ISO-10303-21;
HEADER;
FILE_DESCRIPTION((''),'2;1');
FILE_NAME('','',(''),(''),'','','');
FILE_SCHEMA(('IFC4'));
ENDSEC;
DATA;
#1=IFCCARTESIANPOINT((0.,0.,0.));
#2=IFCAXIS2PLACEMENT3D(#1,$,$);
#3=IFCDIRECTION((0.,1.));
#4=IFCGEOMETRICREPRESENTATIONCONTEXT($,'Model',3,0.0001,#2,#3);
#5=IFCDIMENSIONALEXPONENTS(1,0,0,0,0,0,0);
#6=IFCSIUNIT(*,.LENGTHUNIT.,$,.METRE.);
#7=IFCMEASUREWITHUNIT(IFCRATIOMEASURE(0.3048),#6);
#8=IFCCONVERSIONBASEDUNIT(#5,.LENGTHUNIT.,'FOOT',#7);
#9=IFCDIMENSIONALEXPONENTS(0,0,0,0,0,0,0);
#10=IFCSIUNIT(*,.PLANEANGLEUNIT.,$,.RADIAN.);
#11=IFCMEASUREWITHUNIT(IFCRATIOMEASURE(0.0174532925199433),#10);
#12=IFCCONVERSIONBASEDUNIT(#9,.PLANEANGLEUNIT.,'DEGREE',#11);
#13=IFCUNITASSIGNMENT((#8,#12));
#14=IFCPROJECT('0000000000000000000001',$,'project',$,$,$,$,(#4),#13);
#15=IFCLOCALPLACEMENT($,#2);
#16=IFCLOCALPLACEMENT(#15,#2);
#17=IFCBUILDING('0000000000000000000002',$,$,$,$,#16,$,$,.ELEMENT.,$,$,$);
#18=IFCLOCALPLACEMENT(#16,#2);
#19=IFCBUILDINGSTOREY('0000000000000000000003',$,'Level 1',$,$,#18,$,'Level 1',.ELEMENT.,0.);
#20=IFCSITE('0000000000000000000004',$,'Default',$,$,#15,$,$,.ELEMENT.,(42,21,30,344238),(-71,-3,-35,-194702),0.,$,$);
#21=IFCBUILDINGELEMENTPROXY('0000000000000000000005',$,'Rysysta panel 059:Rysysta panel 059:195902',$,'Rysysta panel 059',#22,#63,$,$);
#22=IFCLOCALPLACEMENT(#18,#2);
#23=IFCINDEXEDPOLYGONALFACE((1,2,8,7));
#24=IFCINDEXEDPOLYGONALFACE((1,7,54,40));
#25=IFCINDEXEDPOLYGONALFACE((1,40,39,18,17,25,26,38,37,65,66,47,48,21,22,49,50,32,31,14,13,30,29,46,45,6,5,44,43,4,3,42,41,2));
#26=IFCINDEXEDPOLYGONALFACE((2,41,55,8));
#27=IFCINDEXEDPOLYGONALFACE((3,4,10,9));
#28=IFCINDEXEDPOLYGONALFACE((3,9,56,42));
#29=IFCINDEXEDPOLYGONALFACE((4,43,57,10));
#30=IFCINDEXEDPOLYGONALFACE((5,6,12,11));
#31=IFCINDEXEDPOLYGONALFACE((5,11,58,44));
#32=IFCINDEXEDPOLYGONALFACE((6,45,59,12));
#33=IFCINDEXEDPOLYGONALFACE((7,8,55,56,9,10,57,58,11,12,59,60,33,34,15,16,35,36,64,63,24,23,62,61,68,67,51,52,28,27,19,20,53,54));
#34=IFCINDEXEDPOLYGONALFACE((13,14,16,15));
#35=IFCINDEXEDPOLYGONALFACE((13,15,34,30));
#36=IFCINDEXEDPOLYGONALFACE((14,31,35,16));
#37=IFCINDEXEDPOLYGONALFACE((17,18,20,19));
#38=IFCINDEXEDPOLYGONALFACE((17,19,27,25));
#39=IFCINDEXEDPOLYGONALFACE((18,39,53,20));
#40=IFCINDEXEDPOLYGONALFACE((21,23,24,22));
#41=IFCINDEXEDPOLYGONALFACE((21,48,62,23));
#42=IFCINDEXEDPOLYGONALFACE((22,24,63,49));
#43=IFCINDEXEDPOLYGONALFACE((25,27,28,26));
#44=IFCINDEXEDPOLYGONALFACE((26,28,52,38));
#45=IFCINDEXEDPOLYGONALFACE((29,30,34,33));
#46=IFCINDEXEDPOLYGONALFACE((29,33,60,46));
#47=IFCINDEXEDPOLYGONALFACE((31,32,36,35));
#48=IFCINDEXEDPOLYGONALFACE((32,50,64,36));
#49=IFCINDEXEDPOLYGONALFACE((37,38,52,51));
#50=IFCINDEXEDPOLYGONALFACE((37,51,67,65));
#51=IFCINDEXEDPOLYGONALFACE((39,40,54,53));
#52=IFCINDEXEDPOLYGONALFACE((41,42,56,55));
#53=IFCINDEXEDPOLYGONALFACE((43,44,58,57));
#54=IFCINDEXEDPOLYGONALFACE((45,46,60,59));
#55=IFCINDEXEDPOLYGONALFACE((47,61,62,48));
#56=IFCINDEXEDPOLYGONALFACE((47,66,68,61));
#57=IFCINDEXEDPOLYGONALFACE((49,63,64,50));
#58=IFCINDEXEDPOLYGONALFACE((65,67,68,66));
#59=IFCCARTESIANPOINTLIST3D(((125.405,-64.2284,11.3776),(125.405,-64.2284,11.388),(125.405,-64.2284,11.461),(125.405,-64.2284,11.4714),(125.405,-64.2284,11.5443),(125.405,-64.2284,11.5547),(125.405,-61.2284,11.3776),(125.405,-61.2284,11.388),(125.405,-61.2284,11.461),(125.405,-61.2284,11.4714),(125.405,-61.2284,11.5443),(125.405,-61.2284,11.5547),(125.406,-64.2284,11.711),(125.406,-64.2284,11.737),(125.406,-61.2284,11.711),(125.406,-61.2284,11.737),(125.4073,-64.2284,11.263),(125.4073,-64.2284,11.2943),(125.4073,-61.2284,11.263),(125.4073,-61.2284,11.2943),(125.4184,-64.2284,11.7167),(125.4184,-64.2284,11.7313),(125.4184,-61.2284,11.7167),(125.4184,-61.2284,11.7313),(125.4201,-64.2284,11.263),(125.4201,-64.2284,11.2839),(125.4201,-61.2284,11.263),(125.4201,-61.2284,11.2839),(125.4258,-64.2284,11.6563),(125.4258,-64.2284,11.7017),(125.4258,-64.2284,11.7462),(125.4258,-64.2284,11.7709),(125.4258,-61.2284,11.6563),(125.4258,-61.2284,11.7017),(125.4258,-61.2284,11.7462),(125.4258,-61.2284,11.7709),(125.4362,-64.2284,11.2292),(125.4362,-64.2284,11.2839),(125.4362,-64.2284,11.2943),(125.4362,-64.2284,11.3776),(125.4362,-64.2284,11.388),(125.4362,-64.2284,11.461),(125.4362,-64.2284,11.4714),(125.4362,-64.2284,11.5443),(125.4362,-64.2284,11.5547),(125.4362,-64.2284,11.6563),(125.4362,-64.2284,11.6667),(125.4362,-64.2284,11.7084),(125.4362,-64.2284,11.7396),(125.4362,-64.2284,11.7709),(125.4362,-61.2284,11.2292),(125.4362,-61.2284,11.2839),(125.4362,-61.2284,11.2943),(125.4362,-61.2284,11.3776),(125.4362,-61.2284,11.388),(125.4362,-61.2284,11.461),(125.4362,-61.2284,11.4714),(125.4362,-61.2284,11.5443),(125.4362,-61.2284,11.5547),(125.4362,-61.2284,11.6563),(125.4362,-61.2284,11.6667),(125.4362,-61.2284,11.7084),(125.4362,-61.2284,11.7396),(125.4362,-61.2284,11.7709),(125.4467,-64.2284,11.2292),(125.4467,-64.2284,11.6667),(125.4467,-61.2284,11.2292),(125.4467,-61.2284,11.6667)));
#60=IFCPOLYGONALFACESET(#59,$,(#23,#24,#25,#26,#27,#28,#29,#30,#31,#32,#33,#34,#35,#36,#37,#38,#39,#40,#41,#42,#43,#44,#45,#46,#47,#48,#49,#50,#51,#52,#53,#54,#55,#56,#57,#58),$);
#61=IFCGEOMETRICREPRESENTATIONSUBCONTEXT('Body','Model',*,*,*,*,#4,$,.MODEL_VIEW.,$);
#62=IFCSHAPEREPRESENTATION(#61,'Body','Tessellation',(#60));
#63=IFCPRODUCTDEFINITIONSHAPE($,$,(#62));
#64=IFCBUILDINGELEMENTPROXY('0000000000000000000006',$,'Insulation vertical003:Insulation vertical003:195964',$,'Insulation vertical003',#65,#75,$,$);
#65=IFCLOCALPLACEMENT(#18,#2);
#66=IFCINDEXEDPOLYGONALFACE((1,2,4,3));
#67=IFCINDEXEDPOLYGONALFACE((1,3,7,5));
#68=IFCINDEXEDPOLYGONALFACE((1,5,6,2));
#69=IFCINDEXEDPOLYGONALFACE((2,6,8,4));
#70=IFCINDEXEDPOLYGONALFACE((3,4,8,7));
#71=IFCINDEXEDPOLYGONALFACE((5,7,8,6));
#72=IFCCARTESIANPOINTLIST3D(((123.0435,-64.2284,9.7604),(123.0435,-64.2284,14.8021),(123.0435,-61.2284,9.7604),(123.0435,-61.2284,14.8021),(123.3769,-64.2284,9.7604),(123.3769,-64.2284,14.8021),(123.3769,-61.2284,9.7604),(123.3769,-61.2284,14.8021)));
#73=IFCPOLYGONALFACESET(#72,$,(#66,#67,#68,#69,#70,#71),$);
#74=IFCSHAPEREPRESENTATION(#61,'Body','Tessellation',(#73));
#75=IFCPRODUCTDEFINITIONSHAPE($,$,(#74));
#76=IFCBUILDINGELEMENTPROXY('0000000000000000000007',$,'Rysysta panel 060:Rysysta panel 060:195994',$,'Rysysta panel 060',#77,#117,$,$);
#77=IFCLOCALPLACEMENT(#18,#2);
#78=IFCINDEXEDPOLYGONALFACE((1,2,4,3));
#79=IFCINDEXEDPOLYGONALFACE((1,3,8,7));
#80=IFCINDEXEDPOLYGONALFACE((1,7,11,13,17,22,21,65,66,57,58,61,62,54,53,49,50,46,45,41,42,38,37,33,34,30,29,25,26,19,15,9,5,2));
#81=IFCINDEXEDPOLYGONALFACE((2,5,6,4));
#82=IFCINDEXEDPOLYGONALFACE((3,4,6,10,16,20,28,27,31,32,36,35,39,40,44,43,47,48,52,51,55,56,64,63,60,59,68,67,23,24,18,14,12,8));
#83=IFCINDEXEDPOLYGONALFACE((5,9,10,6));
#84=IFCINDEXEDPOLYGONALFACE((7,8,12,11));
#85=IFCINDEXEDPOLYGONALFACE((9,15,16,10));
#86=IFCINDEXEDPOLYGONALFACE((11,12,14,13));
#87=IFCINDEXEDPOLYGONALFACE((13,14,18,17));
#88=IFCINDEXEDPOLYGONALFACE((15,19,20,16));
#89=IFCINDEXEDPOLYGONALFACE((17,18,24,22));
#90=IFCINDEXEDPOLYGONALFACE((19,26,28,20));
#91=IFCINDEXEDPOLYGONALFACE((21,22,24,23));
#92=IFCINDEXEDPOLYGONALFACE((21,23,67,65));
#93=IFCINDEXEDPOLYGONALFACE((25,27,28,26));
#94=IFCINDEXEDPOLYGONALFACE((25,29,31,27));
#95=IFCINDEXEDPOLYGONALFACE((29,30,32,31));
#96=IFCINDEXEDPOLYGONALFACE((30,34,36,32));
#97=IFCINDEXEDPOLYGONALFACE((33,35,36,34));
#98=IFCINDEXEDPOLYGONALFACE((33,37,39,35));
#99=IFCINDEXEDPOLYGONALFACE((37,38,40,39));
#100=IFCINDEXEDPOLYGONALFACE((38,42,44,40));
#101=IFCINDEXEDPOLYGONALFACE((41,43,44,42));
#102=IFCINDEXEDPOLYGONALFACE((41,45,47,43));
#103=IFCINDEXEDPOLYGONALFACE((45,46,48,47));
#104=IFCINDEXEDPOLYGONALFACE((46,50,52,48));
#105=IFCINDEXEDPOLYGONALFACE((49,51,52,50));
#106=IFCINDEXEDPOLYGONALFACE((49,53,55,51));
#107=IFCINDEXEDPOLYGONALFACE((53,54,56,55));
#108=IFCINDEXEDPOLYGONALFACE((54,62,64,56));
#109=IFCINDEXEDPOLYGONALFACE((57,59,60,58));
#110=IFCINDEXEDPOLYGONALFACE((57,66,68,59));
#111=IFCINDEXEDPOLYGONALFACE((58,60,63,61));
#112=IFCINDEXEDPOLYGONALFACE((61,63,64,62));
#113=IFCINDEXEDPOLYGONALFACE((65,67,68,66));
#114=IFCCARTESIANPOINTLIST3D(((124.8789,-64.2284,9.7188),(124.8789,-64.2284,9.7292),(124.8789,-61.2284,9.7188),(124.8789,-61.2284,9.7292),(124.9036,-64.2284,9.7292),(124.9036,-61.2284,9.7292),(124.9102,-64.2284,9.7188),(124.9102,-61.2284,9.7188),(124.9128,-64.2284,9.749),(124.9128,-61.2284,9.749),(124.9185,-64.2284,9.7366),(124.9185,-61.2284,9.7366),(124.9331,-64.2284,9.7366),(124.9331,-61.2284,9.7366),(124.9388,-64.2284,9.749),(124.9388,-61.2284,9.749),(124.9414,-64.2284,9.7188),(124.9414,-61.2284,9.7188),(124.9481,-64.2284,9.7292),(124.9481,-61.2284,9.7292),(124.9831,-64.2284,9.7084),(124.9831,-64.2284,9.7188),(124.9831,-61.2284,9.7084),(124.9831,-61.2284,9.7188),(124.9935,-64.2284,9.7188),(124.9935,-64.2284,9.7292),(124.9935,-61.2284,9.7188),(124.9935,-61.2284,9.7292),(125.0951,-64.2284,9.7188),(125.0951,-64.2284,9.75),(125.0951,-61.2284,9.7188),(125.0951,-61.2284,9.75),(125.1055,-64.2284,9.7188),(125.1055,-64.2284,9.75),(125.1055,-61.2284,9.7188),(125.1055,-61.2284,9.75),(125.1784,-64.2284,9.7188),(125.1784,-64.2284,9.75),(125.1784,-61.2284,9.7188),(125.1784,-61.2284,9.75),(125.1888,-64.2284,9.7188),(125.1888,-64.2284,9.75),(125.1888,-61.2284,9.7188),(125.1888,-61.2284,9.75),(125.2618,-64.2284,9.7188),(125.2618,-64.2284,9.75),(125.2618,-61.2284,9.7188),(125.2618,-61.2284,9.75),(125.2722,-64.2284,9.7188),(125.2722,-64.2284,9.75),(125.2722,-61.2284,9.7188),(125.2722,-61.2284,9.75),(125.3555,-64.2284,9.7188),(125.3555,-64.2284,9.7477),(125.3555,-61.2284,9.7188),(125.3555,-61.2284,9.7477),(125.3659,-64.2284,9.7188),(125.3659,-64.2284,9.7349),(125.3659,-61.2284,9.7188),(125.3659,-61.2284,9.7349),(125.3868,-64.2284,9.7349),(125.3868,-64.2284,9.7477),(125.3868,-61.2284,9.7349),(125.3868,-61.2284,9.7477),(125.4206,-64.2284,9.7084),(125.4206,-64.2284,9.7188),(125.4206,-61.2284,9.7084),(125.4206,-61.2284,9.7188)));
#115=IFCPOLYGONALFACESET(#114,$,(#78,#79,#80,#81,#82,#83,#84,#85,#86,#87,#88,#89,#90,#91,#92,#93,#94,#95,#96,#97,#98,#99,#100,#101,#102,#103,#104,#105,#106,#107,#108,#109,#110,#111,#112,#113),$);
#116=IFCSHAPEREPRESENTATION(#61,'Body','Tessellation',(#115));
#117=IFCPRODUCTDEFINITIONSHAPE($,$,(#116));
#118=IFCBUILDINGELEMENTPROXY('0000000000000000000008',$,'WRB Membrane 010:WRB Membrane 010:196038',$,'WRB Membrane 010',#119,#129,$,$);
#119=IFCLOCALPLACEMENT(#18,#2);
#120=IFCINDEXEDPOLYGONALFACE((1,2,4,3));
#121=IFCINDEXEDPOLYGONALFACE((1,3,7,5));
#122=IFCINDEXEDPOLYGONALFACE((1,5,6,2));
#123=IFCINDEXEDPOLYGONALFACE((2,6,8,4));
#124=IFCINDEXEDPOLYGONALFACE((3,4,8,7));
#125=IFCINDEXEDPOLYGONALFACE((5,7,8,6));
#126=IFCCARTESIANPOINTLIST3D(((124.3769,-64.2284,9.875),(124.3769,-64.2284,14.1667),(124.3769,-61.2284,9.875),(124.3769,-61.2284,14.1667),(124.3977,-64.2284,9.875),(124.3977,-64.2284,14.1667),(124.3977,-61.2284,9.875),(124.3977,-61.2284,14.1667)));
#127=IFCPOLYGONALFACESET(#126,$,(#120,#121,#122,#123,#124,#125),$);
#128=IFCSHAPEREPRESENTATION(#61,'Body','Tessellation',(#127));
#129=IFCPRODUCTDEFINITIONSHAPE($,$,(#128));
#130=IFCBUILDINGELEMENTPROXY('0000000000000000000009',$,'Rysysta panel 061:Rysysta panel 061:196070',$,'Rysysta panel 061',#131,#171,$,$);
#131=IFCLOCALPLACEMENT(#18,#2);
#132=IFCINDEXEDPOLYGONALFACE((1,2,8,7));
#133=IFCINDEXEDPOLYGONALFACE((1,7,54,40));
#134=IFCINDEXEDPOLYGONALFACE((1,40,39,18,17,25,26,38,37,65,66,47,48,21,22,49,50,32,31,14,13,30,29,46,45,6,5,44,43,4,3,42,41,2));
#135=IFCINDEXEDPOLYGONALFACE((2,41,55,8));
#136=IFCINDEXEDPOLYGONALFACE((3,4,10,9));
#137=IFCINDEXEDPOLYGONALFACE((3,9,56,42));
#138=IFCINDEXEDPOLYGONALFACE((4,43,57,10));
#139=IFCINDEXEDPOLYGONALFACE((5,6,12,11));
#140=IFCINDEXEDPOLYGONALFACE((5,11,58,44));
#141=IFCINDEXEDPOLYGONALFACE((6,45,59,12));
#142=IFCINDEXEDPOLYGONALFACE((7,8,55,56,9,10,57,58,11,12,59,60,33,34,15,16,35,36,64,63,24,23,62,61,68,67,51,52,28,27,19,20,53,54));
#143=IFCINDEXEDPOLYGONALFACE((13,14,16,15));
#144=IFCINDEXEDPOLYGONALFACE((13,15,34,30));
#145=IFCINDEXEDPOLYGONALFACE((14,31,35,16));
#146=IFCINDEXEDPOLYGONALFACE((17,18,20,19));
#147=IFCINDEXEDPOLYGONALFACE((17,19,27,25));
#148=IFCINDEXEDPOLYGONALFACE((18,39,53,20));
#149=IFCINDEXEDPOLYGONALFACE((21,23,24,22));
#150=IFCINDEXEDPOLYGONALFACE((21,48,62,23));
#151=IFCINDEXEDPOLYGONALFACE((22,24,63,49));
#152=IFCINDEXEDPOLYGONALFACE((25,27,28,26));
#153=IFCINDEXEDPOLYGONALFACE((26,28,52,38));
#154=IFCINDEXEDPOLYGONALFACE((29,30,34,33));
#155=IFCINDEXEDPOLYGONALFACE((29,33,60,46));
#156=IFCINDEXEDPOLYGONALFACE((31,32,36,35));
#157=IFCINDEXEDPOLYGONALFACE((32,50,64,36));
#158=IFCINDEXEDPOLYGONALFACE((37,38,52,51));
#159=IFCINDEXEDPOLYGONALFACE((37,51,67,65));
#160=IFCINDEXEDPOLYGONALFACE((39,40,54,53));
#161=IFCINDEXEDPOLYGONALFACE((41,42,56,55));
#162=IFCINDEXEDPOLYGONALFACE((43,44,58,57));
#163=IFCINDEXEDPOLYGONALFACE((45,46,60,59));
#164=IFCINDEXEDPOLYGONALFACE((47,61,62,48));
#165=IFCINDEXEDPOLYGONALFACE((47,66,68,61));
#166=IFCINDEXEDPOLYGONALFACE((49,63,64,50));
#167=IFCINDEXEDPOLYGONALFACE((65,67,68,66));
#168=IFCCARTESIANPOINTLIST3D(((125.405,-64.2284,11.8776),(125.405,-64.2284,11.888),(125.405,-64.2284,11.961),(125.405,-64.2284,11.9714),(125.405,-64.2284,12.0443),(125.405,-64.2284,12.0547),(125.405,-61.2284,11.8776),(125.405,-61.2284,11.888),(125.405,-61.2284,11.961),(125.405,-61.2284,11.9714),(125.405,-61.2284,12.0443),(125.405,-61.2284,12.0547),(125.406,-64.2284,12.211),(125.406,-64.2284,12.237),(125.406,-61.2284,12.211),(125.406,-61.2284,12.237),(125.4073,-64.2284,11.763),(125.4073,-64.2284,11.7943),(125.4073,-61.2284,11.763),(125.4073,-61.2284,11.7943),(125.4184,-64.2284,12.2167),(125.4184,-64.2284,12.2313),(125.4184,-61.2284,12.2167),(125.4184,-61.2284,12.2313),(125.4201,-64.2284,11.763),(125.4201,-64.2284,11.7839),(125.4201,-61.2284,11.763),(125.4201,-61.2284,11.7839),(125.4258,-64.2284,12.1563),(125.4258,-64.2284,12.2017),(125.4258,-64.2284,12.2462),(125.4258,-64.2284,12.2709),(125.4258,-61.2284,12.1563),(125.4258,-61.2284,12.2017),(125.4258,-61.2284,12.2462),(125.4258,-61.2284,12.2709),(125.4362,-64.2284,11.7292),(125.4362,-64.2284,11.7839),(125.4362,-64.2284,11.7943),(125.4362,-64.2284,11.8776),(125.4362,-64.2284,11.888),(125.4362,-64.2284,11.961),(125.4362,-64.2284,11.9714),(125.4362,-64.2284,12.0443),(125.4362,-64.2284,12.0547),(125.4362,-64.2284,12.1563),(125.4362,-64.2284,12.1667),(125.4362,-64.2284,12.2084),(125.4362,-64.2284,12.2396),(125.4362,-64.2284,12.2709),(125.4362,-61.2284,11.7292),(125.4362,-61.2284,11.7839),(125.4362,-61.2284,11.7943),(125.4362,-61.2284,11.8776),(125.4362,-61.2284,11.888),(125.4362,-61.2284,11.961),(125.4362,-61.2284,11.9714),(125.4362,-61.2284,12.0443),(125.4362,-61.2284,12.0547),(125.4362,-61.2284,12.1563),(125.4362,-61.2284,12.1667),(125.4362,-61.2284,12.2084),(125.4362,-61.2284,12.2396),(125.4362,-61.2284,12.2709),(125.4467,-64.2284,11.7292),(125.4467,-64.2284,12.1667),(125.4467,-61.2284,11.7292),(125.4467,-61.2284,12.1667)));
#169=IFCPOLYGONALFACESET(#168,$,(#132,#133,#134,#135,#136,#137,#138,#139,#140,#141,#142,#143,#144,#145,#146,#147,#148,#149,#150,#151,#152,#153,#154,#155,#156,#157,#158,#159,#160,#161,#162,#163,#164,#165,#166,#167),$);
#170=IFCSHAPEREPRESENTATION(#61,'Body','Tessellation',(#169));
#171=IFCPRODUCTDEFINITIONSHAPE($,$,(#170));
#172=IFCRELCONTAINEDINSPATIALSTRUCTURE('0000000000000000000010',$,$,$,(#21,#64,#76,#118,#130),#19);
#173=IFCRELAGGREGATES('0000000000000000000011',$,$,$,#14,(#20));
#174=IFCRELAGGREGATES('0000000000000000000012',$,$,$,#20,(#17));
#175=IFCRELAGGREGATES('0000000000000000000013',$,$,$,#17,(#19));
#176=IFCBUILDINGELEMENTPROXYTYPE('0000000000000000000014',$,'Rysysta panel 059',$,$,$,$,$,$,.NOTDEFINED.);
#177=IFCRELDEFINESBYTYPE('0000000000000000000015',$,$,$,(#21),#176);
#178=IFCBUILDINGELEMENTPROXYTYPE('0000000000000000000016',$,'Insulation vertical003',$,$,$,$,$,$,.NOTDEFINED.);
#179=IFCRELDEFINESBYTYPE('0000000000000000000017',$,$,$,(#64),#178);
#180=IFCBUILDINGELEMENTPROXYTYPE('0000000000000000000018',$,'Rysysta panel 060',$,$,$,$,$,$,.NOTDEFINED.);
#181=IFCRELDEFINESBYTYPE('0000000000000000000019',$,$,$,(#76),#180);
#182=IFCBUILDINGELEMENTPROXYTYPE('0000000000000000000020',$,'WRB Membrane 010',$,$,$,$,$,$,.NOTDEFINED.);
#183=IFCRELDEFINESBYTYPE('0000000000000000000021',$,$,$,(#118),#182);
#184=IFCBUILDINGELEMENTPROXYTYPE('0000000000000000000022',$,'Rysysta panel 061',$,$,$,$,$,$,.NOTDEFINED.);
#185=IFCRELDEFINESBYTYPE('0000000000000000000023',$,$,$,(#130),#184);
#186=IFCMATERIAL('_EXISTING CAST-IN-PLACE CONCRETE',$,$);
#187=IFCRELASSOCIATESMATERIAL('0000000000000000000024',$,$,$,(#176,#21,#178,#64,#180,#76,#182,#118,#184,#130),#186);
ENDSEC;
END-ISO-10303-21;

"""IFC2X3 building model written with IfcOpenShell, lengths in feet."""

from ifc_helpers import new_model, entity, si_unit, converted_unit, direction, frame, frame_2d, origin, origin_2d_with_axis, place, context, subcontext, project, spatial, polyline, rectangle, outline, extrude, source, transform, mapped, material, type_object, type_shapes, element, save


model = new_model("IFC2X3")

# Units and contexts
model_context = context("Model", 3, precision=0.0001, world=origin(), true_north=direction((0.0, 1.0)))
body_context = subcontext(model_context, "Body", "Model", "MODEL_VIEW")
ifc_project = project(units=[converted_unit("LENGTHUNIT", "FOOT", entity("IfcRatioMeasure", 0.3048), si_unit("LENGTHUNIT", "METRE"), dimensions=[1, 0, 0, 0, 0, 0, 0]), converted_unit("PLANEANGLEUNIT", "DEGREE", entity("IfcRatioMeasure", 0.0174532925199433), si_unit("PLANEANGLEUNIT", "RADIAN"), dimensions=[0, 0, 0, 0, 0, 0, 0])], contexts=[model_context])

# Site, building, storey
site_placement = place(None, origin())
site = spatial("IfcSite", under=ifc_project, at=site_placement, Name="Default", CompositionType="ELEMENT", RefLatitude=(42, 21, 30, 344238), RefLongitude=(-71, -3, -35, -194702), RefElevation=0.0)
building_placement = place(site_placement, origin())
building = spatial("IfcBuilding", under=site, at=building_placement, CompositionType="ELEMENT")
storey_placement = place(building_placement, origin())
storey = spatial("IfcBuildingStorey", under=building, at=storey_placement, Name="Level 1", LongName="Level 1", CompositionType="ELEMENT", Elevation=0.0)

# Building element proxies
ifc_material_1 = material(Name="_EXISTING CAST-IN-PLACE CONCRETE")
building_element_proxy_type_1 = type_object("IfcBuildingElementProxyType", Name="Rysysta panel 059", PredefinedType="NOTDEFINED", material=ifc_material_1)
shared_shape_1 = source(origin(), body_context, "Body", "SweptSolid", [
    extrude(outline(polyline([(-0.1457, -0.022), (0.2918, -0.022), (0.2918, -0.0116), (0.2371, -0.0116), (0.2371, 0.0045), (0.258, 0.0045), (0.258, 0.0173), (0.2267, 0.0173), (0.2267, -0.0116), (0.1434, -0.0116), (0.1434, 0.0196), (0.133, 0.0196), (0.133, -0.0116), (0.06, -0.0116), (0.06, 0.0196), (0.0496, 0.0196), (0.0496, -0.0116), (-0.0233, -0.0116), (-0.0233, 0.0196), (-0.0337, 0.0196), (-0.0337, -0.0116), (-0.1353, -0.0116), (-0.1353, -0.0012), (-0.1807, -0.0012), (-0.1899, 0.0186), (-0.216, 0.0186), (-0.2252, -0.0012), (-0.2498, -0.0012), (-0.2498, -0.0116), (-0.2186, -0.0116), (-0.2103, 0.0062), (-0.1956, 0.0062), (-0.1873, -0.0116), (-0.1457, -0.0116), (-0.1457, -0.022)])), frame((125.4246, -64.2284, 11.521), z_axis=(0.0, 1.0, 0.0), x_axis=(0.0, 0.0, -1.0)), (0.0, 0.0, 1.0), 3.0),
])
type_shapes(building_element_proxy_type_1, [shared_shape_1])
proxy_1_placement = place(storey_placement, origin())
element("IfcBuildingElementProxy", 1, at=proxy_1_placement, inside=storey, type_object=building_element_proxy_type_1, material=ifc_material_1, Name="Rysysta panel 059:Rysysta panel 059:195902", ObjectType="Rysysta panel 059", context=body_context, shape_type="MappedRepresentation", body=[
    mapped(shared_shape_1, transform((0.0, 0.0, 0.0), scale=1.0)),
])
building_element_proxy_type_2 = type_object("IfcBuildingElementProxyType", Name="Insulation vertical003", PredefinedType="NOTDEFINED", material=ifc_material_1)
shared_shape_2 = source(origin(), body_context, "Body", "SweptSolid", [
    extrude(rectangle(XDim=3.0, YDim=0.3333, at=origin_2d_with_axis()), frame((123.2102, -62.7284, 9.7604), z_axis=(0.0, 0.0, 1.0), x_axis=(0.0, 1.0, 0.0)), (0.0, 0.0, 1.0), 5.0417),
])
type_shapes(building_element_proxy_type_2, [shared_shape_2])
proxy_2_placement = place(storey_placement, origin())
element("IfcBuildingElementProxy", 2, at=proxy_2_placement, inside=storey, type_object=building_element_proxy_type_2, material=ifc_material_1, Name="Insulation vertical003:Insulation vertical003:195964", ObjectType="Insulation vertical003", context=body_context, shape_type="MappedRepresentation", body=[
    mapped(shared_shape_2, transform((0.0, 0.0, 0.0), scale=1.0)),
])
building_element_proxy_type_3 = type_object("IfcBuildingElementProxyType", Name="Rysysta panel 060", PredefinedType="NOTDEFINED", material=ifc_material_1)
shared_shape_3 = source(origin(), body_context, "Body", "SweptSolid", [
    extrude(outline(polyline([(0.0116, -0.2918), (0.022, -0.2918), (0.022, 0.1457), (0.0116, 0.1457), (0.0116, 0.1873), (-0.0062, 0.1956), (-0.0062, 0.2103), (0.0116, 0.2186), (0.0116, 0.2498), (0.0012, 0.2498), (0.0012, 0.2252), (-0.0186, 0.216), (-0.0186, 0.1899), (0.0012, 0.1807), (0.0012, 0.1353), (0.0116, 0.1353), (0.0116, 0.0337), (-0.0196, 0.0337), (-0.0196, 0.0233), (0.0116, 0.0233), (0.0116, -0.0496), (-0.0196, -0.0496), (-0.0196, -0.06), (0.0116, -0.06), (0.0116, -0.133), (-0.0196, -0.133), (-0.0196, -0.1434), (0.0116, -0.1434), (0.0116, -0.2267), (-0.0173, -0.2267), (-0.0173, -0.258), (-0.0045, -0.258), (-0.0045, -0.2371), (0.0116, -0.2371), (0.0116, -0.2918)])), frame((125.1288, -64.2284, 9.7304), z_axis=(0.0, 1.0, 0.0), x_axis=(0.0, 0.0, -1.0)), (0.0, 0.0, 1.0), 3.0),
])
type_shapes(building_element_proxy_type_3, [shared_shape_3])
proxy_3_placement = place(storey_placement, origin())
element("IfcBuildingElementProxy", 3, at=proxy_3_placement, inside=storey, type_object=building_element_proxy_type_3, material=ifc_material_1, Name="Rysysta panel 060:Rysysta panel 060:195994", ObjectType="Rysysta panel 060", context=body_context, shape_type="MappedRepresentation", body=[
    mapped(shared_shape_3, transform((0.0, 0.0, 0.0), scale=1.0)),
])
building_element_proxy_type_4 = type_object("IfcBuildingElementProxyType", Name="WRB Membrane 010", PredefinedType="NOTDEFINED", material=ifc_material_1)
shared_shape_4 = source(origin(), body_context, "Body", "SweptSolid", [
    extrude(rectangle(XDim=3.0, YDim=0.0208, at=frame_2d((0.0, 0.0), x_axis=(1.0, 0.0))), frame((124.3873, -62.7284, 9.875), z_axis=(0.0, 0.0, 1.0), x_axis=(0.0, 1.0, 0.0)), (0.0, 0.0, 1.0), 4.2917),
])
type_shapes(building_element_proxy_type_4, [shared_shape_4])
proxy_4_placement = place(storey_placement, origin())
element("IfcBuildingElementProxy", 4, at=proxy_4_placement, inside=storey, type_object=building_element_proxy_type_4, material=ifc_material_1, Name="WRB Membrane 010:WRB Membrane 010:196038", ObjectType="WRB Membrane 010", context=body_context, shape_type="MappedRepresentation", body=[
    mapped(shared_shape_4, transform((0.0, 0.0, 0.0), scale=1.0)),
])
building_element_proxy_type_5 = type_object("IfcBuildingElementProxyType", Name="Rysysta panel 061", PredefinedType="NOTDEFINED", material=ifc_material_1)
shared_shape_5 = source(origin(), body_context, "Body", "SweptSolid", [
    extrude(outline(polyline([(-0.1457, -0.022), (0.2918, -0.022), (0.2918, -0.0116), (0.2371, -0.0116), (0.2371, 0.0045), (0.258, 0.0045), (0.258, 0.0173), (0.2267, 0.0173), (0.2267, -0.0116), (0.1434, -0.0116), (0.1434, 0.0196), (0.133, 0.0196), (0.133, -0.0116), (0.06, -0.0116), (0.06, 0.0196), (0.0496, 0.0196), (0.0496, -0.0116), (-0.0233, -0.0116), (-0.0233, 0.0196), (-0.0337, 0.0196), (-0.0337, -0.0116), (-0.1353, -0.0116), (-0.1353, -0.0012), (-0.1807, -0.0012), (-0.1899, 0.0186), (-0.216, 0.0186), (-0.2252, -0.0012), (-0.2498, -0.0012), (-0.2498, -0.0116), (-0.2186, -0.0116), (-0.2103, 0.0062), (-0.1956, 0.0062), (-0.1873, -0.0116), (-0.1457, -0.0116), (-0.1457, -0.022)])), frame((125.4246, -64.2284, 12.021), z_axis=(0.0, 1.0, 0.0), x_axis=(0.0, 0.0, -1.0)), (0.0, 0.0, 1.0), 3.0),
])
type_shapes(building_element_proxy_type_5, [shared_shape_5])
proxy_5_placement = place(storey_placement, origin())
element("IfcBuildingElementProxy", 5, at=proxy_5_placement, inside=storey, type_object=building_element_proxy_type_5, material=ifc_material_1, Name="Rysysta panel 061:Rysysta panel 061:196070", ObjectType="Rysysta panel 061", context=body_context, shape_type="MappedRepresentation", body=[
    mapped(shared_shape_5, transform((0.0, 0.0, 0.0), scale=1.0)),
])

save(model, "model.ifc")
